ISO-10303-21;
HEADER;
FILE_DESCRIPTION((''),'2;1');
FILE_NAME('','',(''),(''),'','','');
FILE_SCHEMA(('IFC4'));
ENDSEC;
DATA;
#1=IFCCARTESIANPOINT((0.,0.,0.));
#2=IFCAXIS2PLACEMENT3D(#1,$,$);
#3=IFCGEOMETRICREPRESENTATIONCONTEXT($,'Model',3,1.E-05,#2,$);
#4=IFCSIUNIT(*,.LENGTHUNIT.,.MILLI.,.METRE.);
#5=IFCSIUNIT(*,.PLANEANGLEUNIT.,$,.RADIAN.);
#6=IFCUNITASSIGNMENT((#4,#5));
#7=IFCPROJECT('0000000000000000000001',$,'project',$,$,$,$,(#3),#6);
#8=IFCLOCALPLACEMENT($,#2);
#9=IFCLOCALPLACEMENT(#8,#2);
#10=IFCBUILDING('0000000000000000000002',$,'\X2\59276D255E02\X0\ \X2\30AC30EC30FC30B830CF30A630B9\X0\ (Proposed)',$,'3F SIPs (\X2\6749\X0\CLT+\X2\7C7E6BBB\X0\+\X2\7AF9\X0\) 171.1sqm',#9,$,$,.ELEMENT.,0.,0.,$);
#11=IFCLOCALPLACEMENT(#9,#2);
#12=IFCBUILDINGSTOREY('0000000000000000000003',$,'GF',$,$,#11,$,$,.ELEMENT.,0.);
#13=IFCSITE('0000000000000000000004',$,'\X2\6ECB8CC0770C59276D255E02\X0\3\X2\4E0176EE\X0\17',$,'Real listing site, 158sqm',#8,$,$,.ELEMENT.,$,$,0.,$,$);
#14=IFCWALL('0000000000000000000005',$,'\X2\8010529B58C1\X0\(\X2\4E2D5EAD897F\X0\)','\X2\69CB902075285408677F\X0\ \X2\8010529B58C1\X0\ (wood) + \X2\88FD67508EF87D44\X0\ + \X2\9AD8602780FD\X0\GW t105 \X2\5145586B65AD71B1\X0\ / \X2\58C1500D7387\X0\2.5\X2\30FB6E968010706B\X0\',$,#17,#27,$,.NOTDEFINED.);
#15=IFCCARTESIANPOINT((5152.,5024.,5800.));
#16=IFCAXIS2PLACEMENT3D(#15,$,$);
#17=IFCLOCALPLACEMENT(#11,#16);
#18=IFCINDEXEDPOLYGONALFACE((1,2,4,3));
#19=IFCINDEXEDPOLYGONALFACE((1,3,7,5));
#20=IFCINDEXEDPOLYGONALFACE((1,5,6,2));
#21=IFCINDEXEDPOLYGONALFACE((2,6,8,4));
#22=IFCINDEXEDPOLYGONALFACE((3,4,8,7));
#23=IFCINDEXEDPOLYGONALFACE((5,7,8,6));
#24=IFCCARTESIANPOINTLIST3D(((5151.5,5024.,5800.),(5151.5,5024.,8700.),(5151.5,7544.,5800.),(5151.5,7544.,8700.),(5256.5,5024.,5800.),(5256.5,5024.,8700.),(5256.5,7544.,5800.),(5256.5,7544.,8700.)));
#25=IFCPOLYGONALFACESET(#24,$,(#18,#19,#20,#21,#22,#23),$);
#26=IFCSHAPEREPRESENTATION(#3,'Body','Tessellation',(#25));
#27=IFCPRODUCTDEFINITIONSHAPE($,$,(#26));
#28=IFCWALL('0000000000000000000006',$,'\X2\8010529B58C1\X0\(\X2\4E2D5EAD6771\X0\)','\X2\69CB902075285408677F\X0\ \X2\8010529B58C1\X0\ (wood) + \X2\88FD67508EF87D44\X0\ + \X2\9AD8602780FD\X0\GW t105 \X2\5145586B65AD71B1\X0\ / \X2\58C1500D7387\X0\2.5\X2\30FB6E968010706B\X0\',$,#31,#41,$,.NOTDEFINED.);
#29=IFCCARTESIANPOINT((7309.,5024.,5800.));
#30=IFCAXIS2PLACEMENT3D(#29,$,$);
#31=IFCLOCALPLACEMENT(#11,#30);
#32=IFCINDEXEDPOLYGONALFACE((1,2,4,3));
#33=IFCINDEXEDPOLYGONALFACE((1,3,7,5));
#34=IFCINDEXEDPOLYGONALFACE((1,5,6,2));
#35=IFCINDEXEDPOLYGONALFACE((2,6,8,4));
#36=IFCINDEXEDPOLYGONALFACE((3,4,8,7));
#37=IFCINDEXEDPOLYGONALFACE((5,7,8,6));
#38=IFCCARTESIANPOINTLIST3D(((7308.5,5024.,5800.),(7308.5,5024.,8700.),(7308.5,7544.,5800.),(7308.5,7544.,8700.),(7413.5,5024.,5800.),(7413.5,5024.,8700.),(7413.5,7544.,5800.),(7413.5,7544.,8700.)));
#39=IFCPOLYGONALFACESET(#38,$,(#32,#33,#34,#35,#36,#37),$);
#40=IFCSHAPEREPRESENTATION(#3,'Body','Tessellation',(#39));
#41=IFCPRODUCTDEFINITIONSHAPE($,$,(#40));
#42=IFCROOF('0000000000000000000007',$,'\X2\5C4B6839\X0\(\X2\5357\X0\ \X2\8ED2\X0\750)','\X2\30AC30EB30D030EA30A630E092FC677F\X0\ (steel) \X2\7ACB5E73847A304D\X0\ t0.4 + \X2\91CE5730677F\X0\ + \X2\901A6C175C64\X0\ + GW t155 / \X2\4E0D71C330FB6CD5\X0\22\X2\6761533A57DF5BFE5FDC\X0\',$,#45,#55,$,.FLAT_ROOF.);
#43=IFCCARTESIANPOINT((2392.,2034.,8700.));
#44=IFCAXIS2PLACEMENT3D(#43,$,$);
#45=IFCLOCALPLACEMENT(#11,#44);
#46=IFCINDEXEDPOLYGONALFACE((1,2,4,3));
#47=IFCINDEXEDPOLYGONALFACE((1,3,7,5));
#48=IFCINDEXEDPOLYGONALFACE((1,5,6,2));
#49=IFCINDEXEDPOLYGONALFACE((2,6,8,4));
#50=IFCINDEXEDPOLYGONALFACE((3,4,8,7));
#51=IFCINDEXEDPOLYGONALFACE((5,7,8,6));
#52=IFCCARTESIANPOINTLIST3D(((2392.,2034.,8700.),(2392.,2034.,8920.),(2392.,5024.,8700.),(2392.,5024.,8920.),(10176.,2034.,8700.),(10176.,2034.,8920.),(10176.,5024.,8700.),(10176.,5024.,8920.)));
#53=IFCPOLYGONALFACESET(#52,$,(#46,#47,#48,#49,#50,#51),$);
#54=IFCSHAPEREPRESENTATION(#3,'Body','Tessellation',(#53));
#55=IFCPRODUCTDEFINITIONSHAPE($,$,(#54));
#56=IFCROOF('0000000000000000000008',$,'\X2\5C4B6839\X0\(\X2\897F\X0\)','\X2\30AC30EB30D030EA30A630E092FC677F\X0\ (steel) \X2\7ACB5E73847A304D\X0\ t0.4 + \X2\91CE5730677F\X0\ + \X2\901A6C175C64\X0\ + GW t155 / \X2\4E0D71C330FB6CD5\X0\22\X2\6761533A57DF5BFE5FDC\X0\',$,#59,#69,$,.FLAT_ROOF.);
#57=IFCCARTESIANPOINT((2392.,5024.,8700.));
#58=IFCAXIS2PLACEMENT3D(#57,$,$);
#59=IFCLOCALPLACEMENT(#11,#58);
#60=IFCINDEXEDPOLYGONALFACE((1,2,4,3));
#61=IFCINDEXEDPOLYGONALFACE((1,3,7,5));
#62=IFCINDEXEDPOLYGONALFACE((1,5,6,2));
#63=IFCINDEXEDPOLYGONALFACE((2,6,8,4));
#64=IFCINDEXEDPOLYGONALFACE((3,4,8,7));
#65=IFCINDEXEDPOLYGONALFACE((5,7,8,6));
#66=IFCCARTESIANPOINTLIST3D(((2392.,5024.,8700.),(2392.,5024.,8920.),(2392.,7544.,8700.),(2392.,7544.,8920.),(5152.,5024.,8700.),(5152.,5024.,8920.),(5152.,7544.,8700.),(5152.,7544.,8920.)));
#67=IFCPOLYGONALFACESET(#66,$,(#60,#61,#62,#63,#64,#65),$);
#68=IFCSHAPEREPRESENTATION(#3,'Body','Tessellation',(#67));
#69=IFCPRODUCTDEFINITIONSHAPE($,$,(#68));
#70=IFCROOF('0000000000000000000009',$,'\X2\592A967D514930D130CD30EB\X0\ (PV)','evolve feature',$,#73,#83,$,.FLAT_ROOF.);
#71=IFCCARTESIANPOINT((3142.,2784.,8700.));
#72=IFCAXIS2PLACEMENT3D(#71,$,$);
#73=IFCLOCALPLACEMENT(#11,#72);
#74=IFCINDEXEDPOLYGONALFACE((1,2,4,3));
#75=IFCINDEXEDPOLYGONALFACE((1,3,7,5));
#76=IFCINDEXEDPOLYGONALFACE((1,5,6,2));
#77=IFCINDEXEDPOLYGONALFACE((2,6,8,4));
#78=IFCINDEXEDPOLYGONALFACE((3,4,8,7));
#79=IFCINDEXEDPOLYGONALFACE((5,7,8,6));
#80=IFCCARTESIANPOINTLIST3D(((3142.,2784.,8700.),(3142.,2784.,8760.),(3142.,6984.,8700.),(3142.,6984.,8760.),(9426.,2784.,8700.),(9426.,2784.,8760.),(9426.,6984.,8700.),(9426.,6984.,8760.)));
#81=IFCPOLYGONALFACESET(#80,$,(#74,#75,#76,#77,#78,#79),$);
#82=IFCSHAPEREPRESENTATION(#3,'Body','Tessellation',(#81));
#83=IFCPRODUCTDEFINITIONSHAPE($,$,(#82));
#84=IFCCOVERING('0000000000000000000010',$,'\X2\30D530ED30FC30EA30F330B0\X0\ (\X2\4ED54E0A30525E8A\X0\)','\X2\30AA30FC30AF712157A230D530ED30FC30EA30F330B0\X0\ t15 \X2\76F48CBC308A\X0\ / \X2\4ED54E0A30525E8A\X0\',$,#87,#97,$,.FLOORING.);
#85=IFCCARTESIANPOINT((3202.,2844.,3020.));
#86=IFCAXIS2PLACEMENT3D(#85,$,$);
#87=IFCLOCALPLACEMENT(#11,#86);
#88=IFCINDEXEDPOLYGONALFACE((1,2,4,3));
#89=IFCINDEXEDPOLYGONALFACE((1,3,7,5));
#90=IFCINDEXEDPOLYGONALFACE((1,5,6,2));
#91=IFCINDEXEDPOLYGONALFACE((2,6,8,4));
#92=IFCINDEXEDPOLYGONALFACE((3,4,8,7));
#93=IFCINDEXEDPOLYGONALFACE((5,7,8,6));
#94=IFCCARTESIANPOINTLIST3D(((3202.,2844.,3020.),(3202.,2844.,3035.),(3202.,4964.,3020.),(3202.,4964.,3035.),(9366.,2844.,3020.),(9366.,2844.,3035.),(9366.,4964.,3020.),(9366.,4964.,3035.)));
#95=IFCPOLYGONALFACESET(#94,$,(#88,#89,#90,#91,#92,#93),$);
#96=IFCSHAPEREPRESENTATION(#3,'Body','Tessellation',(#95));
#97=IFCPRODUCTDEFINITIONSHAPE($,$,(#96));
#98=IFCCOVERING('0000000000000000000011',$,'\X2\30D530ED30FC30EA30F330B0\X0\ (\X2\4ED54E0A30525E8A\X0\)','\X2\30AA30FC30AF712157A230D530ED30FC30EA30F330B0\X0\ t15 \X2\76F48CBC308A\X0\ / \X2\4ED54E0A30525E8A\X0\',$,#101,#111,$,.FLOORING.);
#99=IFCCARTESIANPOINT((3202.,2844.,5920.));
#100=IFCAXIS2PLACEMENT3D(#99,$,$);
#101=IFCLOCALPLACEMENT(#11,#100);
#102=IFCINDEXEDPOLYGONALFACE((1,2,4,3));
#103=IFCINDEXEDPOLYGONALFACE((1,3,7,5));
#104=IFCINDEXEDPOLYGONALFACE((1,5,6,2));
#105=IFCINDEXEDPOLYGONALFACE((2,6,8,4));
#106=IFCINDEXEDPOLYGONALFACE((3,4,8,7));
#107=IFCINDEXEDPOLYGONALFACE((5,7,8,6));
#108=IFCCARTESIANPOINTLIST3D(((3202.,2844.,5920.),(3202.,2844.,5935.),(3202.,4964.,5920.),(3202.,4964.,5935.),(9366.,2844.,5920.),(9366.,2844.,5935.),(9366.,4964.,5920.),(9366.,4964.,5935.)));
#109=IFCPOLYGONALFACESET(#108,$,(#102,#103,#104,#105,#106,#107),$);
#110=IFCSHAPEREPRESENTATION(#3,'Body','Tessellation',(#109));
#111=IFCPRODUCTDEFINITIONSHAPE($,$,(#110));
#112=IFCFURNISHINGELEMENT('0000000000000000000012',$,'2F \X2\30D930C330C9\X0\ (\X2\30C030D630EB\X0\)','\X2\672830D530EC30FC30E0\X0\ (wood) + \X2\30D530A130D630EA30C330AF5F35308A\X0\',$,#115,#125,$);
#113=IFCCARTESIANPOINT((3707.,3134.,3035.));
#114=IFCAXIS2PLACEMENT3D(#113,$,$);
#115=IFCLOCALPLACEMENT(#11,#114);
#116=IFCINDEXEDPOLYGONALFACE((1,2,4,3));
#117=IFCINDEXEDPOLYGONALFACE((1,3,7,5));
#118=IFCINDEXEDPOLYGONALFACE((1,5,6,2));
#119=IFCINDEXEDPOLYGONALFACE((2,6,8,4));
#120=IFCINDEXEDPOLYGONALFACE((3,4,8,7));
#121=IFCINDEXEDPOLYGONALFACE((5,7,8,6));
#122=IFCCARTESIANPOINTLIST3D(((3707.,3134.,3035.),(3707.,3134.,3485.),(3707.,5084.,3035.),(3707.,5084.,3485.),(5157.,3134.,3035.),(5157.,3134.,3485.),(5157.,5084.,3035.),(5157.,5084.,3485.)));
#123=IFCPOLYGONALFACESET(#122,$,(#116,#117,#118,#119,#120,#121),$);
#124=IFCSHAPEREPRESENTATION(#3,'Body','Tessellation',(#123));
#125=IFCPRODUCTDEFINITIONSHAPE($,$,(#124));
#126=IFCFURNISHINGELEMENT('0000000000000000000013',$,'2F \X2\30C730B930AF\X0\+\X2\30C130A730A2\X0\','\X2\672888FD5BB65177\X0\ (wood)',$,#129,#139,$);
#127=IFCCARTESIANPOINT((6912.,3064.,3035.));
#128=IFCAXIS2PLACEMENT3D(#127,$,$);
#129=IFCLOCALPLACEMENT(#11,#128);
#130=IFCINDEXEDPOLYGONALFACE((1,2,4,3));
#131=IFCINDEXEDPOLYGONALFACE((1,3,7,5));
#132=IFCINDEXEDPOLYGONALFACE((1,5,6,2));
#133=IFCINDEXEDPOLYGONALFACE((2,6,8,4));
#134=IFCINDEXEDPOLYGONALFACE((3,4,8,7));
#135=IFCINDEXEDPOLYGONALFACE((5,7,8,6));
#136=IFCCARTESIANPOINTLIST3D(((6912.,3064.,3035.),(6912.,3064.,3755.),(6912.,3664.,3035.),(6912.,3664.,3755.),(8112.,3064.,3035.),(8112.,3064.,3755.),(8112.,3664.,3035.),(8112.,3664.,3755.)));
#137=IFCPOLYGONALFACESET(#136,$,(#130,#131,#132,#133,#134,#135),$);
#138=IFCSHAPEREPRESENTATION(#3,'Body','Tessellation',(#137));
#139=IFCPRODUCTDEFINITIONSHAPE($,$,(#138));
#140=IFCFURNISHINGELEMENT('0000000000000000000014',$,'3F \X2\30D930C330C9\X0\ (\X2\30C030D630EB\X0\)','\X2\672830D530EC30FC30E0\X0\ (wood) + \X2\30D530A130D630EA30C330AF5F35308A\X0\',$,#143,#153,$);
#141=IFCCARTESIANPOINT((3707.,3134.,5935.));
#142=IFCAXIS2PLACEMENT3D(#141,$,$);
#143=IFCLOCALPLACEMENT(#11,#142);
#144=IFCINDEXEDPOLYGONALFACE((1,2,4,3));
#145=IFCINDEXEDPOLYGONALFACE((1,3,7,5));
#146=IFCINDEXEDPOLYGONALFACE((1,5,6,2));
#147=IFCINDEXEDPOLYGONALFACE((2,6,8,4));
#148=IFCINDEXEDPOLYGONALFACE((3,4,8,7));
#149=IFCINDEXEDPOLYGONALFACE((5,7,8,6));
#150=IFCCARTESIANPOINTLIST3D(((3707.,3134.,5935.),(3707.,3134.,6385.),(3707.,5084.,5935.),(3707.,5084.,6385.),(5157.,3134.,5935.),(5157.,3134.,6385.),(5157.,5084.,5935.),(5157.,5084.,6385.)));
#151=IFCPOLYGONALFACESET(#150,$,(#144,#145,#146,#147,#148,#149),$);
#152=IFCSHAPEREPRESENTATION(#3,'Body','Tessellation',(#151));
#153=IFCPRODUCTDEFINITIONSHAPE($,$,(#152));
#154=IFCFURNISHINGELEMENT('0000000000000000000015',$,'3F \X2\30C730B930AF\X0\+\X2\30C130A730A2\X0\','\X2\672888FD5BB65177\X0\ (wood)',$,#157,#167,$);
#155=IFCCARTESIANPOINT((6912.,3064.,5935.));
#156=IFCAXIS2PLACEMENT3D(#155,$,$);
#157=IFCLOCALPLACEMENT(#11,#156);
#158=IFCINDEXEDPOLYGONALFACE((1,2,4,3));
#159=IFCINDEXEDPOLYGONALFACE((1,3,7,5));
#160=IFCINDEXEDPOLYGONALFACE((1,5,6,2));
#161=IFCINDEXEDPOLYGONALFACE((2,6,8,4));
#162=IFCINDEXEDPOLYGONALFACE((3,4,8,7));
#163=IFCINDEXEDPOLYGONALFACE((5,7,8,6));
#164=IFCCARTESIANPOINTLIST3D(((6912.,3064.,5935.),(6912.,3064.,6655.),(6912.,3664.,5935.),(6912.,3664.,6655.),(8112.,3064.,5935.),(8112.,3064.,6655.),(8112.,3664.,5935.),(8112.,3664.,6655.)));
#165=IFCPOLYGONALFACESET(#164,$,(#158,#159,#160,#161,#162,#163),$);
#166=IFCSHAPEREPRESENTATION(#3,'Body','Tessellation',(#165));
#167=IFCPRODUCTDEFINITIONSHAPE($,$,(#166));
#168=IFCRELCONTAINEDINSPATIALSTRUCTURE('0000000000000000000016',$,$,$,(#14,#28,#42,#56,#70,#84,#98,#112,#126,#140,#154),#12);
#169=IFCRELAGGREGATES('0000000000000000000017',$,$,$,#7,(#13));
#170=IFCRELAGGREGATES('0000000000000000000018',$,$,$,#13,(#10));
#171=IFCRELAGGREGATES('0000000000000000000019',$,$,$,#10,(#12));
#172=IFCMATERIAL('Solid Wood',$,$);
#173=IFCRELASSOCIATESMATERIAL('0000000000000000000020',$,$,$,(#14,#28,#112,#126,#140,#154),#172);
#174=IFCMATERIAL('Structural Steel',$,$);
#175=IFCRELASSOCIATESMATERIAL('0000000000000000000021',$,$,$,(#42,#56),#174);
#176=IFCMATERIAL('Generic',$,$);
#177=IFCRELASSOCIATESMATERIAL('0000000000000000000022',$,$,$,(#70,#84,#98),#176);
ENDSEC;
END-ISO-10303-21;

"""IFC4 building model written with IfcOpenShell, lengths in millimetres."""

from ifc_helpers import new_model, si_unit, frame, frame_2d, origin, place, context, project, spatial, rectangle, extrude, material, element, save


model = new_model("IFC4")

# Units and contexts
model_context = context("Model", 3, precision=1e-05, world=origin())
ifc_project = project(units=[si_unit("LENGTHUNIT", "METRE", prefix="MILLI"), si_unit("PLANEANGLEUNIT", "RADIAN")], contexts=[model_context])

# Site, building, storey
site_placement = place(None, origin())
site = spatial("IfcSite", under=ifc_project, at=site_placement, Name="滋賀県大津市3丁目17", ObjectType="Real listing site, 158sqm", CompositionType="ELEMENT", RefElevation=0.0)
building_placement = place(site_placement, origin())
building = spatial("IfcBuilding", under=site, at=building_placement, Name="大津市 ガレージハウス (Proposed)", ObjectType="3F SIPs (杉CLT+籾殻+竹) 171.1sqm", CompositionType="ELEMENT", ElevationOfRefHeight=0.0, ElevationOfTerrain=0.0)
storey_placement = place(building_placement, origin())
storey = spatial("IfcBuildingStorey", under=building, at=storey_placement, Name="GF", CompositionType="ELEMENT", Elevation=0.0)

# Shared definitions
ifc_material_1 = material(Name="Solid Wood")

# Walls
wall_1_placement = place(storey_placement, frame((5152.0, 5024.0, 5800.0)))
element("IfcWall", 1, at=wall_1_placement, inside=storey, material=ifc_material_1, Name="耐力壁(中庭西)", Description="構造用合板 耐力壁 (wood) + 製材軸組 + 高性能GW t105 充填断熱 / 壁倍率2.5・準耐火", PredefinedType="NOTDEFINED", context=model_context, shape_type="SweptSolid", body=[
    extrude(rectangle(XDim=105.0, YDim=2520.0, at=frame_2d((52.0, 1260.0))), frame((5152.0, 5024.0, 5800.0)), (0.0, 0.0, 1.0), 2900.0),
])
wall_2_placement = place(storey_placement, frame((7309.0, 5024.0, 5800.0)))
element("IfcWall", 2, at=wall_2_placement, inside=storey, material=ifc_material_1, Name="耐力壁(中庭東)", Description="構造用合板 耐力壁 (wood) + 製材軸組 + 高性能GW t105 充填断熱 / 壁倍率2.5・準耐火", PredefinedType="NOTDEFINED", context=model_context, shape_type="SweptSolid", body=[
    extrude(rectangle(XDim=105.0, YDim=2520.0, at=frame_2d((52.0, 1260.0))), frame((7309.0, 5024.0, 5800.0)), (0.0, 0.0, 1.0), 2900.0),
])

# Roofs
ifc_material_2 = material(Name="Structural Steel")
roof_1_placement = place(storey_placement, frame((2392.0, 2034.0, 8700.0)))
element("IfcRoof", 3, at=roof_1_placement, inside=storey, material=ifc_material_2, Name="屋根(南 軒750)", Description="ガルバリウム鋼板 (steel) 立平葺き t0.4 + 野地板 + 通気層 + GW t155 / 不燃・法22条区域対応", PredefinedType="FLAT_ROOF", context=model_context, shape_type="SweptSolid", body=[
    extrude(rectangle(XDim=7784.0, YDim=2990.0, at=frame_2d((3892.0, 1495.0))), frame((2392.0, 2034.0, 8700.0)), (0.0, 0.0, 1.0), 220.0),
])
roof_2_placement = place(storey_placement, frame((2392.0, 5024.0, 8700.0)))
element("IfcRoof", 4, at=roof_2_placement, inside=storey, material=ifc_material_2, Name="屋根(西)", Description="ガルバリウム鋼板 (steel) 立平葺き t0.4 + 野地板 + 通気層 + GW t155 / 不燃・法22条区域対応", PredefinedType="FLAT_ROOF", context=model_context, shape_type="SweptSolid", body=[
    extrude(rectangle(XDim=2760.0, YDim=2520.0, at=frame_2d((1380.0, 1260.0))), frame((2392.0, 5024.0, 8700.0)), (0.0, 0.0, 1.0), 220.0),
])
ifc_material_3 = material(Name="Generic")
roof_3_placement = place(storey_placement, frame((3142.0, 2784.0, 8700.0)))
element("IfcRoof", 5, at=roof_3_placement, inside=storey, material=ifc_material_3, Name="太陽光パネル (PV)", Description="evolve feature", PredefinedType="FLAT_ROOF", context=model_context, shape_type="SweptSolid", body=[
    extrude(rectangle(XDim=6284.0, YDim=4200.0, at=frame_2d((3142.0, 2100.0))), frame((3142.0, 2784.0, 8700.0)), (0.0, 0.0, 1.0), 60.0),
])

# Coverings
covering_1_placement = place(storey_placement, frame((3202.0, 2844.0, 3020.0)))
element("IfcCovering", 6, at=covering_1_placement, inside=storey, material=ifc_material_3, Name="フローリング (仕上げ床)", Description="オーク無垢フローリング t15 直貼り / 仕上げ床", PredefinedType="FLOORING", context=model_context, shape_type="SweptSolid", body=[
    extrude(rectangle(XDim=6164.0, YDim=2120.0, at=frame_2d((3082.0, 1060.0))), frame((3202.0, 2844.0, 3020.0)), (0.0, 0.0, 1.0), 15.0),
])
covering_2_placement = place(storey_placement, frame((3202.0, 2844.0, 5920.0)))
element("IfcCovering", 7, at=covering_2_placement, inside=storey, material=ifc_material_3, Name="フローリング (仕上げ床)", Description="オーク無垢フローリング t15 直貼り / 仕上げ床", PredefinedType="FLOORING", context=model_context, shape_type="SweptSolid", body=[
    extrude(rectangle(XDim=6164.0, YDim=2120.0, at=frame_2d((3082.0, 1060.0))), frame((3202.0, 2844.0, 5920.0)), (0.0, 0.0, 1.0), 15.0),
])

# Furnishing elements
furnishing_1_placement = place(storey_placement, frame((3707.0, 3134.0, 3035.0)))
element("IfcFurnishingElement", 8, at=furnishing_1_placement, inside=storey, material=ifc_material_1, Name="2F ベッド (ダブル)", Description="木フレーム (wood) + ファブリック張り", context=model_context, shape_type="SweptSolid", body=[
    extrude(rectangle(XDim=1450.0, YDim=1950.0, at=frame_2d((725.0, 975.0))), frame((3707.0, 3134.0, 3035.0)), (0.0, 0.0, 1.0), 450.0),
])
furnishing_2_placement = place(storey_placement, frame((6912.0, 3064.0, 3035.0)))
element("IfcFurnishingElement", 9, at=furnishing_2_placement, inside=storey, material=ifc_material_1, Name="2F デスク+チェア", Description="木製家具 (wood)", context=model_context, shape_type="SweptSolid", body=[
    extrude(rectangle(XDim=1200.0, YDim=600.0, at=frame_2d((600.0, 300.0))), frame((6912.0, 3064.0, 3035.0)), (0.0, 0.0, 1.0), 720.0),
])
furnishing_3_placement = place(storey_placement, frame((3707.0, 3134.0, 5935.0)))
element("IfcFurnishingElement", 10, at=furnishing_3_placement, inside=storey, material=ifc_material_1, Name="3F ベッド (ダブル)", Description="木フレーム (wood) + ファブリック張り", context=model_context, shape_type="SweptSolid", body=[
    extrude(rectangle(XDim=1450.0, YDim=1950.0, at=frame_2d((725.0, 975.0))), frame((3707.0, 3134.0, 5935.0)), (0.0, 0.0, 1.0), 450.0),
])
furnishing_4_placement = place(storey_placement, frame((6912.0, 3064.0, 5935.0)))
element("IfcFurnishingElement", 11, at=furnishing_4_placement, inside=storey, material=ifc_material_1, Name="3F デスク+チェア", Description="木製家具 (wood)", context=model_context, shape_type="SweptSolid", body=[
    extrude(rectangle(XDim=1200.0, YDim=600.0, at=frame_2d((600.0, 300.0))), frame((6912.0, 3064.0, 5935.0)), (0.0, 0.0, 1.0), 720.0),
])

save(model, "model.ifc")
